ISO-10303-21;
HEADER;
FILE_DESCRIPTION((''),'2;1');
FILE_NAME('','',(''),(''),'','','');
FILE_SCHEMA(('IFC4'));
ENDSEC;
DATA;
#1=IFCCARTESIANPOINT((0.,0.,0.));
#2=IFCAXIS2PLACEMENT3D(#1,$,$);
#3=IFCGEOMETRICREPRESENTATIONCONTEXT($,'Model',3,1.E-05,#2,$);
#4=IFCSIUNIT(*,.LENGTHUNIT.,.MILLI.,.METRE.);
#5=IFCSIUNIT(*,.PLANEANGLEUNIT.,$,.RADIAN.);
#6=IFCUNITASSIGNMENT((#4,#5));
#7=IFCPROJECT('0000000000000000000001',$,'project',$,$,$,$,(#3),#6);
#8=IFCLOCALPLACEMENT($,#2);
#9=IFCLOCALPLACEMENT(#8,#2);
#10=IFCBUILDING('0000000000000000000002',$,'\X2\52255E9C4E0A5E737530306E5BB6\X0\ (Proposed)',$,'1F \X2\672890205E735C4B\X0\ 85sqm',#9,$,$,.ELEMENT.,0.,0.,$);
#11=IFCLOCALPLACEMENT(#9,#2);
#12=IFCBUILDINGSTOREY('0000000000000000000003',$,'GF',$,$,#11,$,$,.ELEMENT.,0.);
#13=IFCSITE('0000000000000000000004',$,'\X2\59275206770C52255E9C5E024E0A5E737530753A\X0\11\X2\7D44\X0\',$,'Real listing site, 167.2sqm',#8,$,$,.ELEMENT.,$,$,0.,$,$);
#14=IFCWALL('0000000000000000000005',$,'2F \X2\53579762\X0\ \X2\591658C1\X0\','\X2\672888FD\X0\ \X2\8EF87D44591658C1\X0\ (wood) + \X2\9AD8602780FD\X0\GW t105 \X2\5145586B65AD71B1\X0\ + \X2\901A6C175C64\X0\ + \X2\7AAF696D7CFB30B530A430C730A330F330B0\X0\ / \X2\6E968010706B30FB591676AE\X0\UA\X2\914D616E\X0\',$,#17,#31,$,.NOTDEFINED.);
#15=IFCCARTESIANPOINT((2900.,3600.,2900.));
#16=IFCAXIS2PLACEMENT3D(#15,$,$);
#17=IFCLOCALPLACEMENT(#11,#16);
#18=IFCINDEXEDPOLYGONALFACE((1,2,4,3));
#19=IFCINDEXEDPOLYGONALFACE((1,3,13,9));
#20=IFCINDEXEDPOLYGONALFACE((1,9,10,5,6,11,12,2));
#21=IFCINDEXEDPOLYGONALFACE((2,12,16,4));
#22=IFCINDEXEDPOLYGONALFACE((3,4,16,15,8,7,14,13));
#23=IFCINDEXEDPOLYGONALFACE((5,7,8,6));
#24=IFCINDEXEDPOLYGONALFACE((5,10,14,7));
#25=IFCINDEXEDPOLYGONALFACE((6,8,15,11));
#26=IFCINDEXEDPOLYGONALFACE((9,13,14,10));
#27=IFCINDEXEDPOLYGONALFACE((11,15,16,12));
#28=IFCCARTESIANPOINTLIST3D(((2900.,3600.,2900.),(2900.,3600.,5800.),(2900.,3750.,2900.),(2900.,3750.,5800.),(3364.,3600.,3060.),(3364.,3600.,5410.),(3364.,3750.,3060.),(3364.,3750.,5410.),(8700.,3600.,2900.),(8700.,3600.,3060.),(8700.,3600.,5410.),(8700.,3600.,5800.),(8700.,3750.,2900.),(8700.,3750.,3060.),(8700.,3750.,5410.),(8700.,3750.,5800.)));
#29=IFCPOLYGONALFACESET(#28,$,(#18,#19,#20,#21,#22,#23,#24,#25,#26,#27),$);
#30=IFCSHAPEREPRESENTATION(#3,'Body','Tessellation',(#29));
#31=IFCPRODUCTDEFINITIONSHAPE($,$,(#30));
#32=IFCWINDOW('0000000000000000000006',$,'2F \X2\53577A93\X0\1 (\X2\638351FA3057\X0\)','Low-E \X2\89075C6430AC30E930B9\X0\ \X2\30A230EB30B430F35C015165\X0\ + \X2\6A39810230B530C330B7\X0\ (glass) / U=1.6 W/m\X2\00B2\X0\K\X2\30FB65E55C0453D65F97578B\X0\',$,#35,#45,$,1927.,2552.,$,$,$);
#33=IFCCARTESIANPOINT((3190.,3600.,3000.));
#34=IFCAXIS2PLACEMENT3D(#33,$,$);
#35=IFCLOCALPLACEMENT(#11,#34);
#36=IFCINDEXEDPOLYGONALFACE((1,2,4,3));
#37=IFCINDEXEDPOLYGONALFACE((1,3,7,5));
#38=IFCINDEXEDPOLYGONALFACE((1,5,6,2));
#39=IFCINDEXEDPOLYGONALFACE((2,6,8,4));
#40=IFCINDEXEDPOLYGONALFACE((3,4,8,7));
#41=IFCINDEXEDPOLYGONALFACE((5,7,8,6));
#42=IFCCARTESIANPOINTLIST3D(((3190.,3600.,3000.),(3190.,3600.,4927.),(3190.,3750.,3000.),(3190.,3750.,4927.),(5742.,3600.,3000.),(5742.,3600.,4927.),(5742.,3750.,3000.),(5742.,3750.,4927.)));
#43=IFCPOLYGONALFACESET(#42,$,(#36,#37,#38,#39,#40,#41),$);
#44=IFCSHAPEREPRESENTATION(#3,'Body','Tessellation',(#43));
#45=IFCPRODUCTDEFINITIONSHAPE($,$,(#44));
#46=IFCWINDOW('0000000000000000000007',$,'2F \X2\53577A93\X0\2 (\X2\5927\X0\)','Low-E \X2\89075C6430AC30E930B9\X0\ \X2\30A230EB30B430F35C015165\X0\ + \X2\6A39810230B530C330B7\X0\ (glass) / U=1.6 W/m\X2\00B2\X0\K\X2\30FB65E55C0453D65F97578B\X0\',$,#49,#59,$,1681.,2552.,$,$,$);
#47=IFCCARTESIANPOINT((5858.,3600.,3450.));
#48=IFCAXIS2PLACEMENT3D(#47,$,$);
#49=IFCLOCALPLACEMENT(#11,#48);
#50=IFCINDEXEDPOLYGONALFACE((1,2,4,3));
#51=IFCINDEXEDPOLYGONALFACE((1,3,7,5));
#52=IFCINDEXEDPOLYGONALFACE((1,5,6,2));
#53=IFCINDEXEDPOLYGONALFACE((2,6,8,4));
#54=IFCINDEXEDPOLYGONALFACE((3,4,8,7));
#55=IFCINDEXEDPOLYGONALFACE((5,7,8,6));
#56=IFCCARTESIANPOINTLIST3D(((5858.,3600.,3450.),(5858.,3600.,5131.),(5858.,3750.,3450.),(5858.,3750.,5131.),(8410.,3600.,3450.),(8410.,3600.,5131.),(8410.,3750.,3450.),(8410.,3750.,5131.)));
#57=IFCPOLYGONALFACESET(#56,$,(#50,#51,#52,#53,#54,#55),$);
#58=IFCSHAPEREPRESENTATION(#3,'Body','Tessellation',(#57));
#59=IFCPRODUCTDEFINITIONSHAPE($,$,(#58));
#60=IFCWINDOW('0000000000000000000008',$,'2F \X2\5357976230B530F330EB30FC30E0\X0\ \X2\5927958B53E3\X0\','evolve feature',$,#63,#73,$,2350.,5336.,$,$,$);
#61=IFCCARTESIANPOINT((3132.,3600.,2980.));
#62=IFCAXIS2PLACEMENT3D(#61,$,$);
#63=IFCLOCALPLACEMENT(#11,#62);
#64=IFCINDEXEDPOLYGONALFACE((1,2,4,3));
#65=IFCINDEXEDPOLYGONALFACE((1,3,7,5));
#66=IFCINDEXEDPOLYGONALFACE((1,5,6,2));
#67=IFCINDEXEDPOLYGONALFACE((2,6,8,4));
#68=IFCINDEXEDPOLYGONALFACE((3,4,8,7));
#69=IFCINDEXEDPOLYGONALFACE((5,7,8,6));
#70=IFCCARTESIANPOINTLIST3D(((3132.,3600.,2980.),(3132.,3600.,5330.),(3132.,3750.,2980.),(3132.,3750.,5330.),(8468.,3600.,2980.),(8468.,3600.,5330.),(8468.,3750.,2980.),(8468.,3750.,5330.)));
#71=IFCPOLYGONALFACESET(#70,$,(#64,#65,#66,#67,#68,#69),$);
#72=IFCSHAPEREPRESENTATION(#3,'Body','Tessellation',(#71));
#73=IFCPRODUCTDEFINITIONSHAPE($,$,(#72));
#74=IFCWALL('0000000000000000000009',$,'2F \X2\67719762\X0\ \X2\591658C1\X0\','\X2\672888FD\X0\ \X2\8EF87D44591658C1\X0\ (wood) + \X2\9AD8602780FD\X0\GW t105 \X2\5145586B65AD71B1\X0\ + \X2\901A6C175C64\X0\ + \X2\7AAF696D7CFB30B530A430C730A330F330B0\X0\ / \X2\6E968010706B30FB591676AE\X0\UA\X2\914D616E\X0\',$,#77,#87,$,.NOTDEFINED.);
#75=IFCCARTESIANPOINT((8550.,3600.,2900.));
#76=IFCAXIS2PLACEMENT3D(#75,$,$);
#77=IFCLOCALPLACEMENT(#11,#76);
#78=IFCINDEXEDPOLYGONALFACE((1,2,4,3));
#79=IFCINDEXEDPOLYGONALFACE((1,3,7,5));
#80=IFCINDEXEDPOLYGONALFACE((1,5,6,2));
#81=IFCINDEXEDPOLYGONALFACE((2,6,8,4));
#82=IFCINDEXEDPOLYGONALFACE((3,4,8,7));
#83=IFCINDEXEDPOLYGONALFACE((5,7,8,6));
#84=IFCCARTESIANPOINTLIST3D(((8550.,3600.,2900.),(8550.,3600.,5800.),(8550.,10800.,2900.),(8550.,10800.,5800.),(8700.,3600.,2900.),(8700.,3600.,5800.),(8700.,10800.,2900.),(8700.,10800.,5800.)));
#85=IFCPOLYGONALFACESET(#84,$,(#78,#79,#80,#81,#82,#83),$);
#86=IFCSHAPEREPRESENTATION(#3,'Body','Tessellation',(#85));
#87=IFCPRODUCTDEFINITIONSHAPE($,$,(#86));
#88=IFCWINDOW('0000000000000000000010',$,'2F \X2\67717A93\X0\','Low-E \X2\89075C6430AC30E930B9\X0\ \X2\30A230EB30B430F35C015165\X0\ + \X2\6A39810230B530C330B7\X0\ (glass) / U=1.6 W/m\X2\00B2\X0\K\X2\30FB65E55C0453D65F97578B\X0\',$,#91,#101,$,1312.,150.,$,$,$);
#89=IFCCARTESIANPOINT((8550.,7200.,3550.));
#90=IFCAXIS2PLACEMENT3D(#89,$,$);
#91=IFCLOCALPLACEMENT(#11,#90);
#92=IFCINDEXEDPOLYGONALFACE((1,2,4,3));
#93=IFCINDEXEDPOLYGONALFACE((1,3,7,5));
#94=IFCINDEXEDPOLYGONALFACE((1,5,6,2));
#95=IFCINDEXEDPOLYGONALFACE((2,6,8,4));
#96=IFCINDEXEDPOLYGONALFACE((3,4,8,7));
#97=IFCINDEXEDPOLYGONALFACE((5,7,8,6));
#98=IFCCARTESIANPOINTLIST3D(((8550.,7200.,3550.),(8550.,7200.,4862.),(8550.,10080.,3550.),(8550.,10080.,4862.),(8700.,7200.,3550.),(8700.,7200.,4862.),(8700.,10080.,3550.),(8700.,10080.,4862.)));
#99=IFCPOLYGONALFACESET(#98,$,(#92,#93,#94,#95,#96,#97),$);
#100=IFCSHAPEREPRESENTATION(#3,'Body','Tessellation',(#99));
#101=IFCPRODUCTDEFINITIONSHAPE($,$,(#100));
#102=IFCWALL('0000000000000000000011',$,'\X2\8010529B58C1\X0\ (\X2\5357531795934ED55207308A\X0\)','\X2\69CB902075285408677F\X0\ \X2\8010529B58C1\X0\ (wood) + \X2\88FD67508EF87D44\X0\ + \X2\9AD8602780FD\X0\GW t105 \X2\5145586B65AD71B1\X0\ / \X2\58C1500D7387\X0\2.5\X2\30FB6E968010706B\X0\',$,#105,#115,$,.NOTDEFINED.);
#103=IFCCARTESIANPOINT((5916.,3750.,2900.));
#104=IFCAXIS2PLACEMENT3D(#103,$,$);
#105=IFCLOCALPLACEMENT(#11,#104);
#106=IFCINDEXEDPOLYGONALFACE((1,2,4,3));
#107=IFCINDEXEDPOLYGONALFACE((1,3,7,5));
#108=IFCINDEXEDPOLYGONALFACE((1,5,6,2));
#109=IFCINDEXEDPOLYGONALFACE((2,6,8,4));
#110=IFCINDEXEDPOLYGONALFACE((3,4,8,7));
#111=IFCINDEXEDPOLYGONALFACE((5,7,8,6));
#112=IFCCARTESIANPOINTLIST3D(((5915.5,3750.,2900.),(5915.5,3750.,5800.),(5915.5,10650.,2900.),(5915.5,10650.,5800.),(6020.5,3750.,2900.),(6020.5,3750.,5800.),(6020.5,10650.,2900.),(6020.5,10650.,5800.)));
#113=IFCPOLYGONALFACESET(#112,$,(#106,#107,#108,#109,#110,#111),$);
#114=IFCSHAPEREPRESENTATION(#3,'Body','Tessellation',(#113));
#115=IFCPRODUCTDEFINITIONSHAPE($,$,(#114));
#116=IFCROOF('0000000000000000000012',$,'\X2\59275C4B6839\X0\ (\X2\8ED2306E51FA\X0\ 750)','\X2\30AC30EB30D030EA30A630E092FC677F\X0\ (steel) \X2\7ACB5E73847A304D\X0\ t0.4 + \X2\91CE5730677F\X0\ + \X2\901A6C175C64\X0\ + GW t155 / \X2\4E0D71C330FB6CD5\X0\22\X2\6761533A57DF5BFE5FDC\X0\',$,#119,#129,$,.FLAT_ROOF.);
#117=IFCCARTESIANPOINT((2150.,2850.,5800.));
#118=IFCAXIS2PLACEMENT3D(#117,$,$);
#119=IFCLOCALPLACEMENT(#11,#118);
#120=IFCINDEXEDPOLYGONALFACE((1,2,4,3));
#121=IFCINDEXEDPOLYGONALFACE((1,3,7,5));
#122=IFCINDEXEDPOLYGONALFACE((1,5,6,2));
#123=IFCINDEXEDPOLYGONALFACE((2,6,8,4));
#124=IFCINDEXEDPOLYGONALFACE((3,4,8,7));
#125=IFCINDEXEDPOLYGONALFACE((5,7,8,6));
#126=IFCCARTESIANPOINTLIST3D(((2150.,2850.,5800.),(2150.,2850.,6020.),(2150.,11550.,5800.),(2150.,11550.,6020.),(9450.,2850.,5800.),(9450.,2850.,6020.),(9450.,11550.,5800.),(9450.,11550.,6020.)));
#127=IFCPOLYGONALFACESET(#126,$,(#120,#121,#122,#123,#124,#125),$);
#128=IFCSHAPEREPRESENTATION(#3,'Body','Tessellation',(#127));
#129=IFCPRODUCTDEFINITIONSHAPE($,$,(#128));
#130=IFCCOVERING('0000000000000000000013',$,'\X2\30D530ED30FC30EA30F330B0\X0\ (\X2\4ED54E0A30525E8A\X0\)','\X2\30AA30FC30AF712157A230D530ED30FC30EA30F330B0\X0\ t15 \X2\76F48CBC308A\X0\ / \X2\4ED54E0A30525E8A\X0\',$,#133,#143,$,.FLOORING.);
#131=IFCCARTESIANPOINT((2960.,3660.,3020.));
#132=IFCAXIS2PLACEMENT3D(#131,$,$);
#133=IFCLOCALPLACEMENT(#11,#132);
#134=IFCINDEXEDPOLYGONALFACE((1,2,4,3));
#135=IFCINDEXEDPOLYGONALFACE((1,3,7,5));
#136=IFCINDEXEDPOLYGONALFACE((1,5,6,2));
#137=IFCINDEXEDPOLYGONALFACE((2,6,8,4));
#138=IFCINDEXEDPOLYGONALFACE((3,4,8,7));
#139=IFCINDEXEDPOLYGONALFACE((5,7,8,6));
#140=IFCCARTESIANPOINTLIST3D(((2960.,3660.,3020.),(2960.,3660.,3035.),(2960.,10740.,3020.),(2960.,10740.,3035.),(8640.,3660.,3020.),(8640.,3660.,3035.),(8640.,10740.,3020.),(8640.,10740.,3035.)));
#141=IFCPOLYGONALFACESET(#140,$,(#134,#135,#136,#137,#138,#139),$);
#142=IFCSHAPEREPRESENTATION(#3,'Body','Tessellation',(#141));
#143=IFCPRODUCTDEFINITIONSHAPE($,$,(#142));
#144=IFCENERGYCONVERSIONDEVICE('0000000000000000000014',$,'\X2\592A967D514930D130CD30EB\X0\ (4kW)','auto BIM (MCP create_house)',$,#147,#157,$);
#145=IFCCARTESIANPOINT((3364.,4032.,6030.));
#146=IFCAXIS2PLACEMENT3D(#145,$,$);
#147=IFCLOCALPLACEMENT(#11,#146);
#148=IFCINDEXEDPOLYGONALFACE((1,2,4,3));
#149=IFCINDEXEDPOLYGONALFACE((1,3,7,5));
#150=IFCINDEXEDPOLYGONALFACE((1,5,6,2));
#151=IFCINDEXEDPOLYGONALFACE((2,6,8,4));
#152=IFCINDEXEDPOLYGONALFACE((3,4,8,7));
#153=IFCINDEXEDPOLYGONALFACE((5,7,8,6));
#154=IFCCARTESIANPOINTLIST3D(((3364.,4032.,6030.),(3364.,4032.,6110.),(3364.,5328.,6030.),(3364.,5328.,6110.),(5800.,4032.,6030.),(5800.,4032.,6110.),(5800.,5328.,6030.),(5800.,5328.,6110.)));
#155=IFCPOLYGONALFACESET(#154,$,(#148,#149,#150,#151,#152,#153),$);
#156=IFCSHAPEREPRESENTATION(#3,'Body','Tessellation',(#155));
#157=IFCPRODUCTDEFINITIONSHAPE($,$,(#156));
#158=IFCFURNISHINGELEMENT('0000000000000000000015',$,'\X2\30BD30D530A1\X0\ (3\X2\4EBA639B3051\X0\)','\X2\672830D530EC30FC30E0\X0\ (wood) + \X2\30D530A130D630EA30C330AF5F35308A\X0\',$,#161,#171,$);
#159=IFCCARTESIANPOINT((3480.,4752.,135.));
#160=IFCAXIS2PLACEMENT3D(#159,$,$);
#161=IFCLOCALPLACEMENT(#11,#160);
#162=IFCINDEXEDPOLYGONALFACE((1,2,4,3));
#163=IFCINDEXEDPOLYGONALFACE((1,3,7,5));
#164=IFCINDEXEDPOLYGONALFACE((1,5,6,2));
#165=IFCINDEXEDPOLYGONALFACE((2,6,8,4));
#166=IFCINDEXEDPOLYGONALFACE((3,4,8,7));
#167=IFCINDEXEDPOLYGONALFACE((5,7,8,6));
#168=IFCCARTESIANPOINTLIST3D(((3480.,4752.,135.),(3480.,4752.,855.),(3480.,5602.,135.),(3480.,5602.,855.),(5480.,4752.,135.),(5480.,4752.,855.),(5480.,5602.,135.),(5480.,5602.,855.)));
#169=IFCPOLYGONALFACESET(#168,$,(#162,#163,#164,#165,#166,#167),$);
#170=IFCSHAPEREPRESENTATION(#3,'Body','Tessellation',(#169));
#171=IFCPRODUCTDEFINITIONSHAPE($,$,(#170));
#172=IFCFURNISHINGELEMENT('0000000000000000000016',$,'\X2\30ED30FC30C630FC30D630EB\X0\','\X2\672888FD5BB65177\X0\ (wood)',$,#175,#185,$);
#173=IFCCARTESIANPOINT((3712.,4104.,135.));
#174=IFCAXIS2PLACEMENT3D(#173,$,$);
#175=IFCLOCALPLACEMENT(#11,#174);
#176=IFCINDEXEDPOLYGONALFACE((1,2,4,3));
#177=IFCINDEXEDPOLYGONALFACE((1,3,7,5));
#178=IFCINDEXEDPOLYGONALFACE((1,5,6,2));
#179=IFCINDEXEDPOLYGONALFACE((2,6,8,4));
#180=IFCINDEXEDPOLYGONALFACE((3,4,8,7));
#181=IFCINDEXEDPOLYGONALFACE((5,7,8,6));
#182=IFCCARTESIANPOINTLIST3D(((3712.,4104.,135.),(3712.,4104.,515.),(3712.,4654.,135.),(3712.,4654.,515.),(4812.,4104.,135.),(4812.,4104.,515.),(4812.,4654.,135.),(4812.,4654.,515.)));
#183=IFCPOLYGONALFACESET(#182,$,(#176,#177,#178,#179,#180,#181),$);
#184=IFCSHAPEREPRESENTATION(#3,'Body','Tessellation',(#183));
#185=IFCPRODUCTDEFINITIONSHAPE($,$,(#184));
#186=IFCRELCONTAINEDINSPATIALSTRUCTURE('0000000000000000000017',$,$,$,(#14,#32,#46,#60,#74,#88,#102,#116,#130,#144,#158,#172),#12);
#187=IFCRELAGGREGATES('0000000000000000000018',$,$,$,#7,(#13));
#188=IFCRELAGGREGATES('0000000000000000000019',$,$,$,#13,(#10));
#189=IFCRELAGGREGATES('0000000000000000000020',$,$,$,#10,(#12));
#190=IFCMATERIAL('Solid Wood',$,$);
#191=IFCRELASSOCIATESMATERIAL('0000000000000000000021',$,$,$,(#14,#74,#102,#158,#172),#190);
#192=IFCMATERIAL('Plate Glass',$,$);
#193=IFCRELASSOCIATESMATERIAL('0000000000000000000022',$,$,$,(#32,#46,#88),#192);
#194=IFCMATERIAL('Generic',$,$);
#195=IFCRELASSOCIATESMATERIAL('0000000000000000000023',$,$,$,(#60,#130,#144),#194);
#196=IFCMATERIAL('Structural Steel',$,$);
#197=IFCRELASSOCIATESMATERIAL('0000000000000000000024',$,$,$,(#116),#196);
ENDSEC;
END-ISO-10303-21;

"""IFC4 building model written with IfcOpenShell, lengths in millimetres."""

from ifc_helpers import new_model, si_unit, frame, frame_2d, origin, place, context, project, spatial, rectangle, extrude, material, element, fill, save


model = new_model("IFC4")

# Units and contexts
model_context = context("Model", 3, precision=1e-05, world=origin())
ifc_project = project(units=[si_unit("LENGTHUNIT", "METRE", prefix="MILLI"), si_unit("PLANEANGLEUNIT", "RADIAN")], contexts=[model_context])

# Site, building, storey
site_placement = place(None, origin())
site = spatial("IfcSite", under=ifc_project, at=site_placement, Name="大分県別府市上平田町11組", ObjectType="Real listing site, 167.2sqm", CompositionType="ELEMENT", RefElevation=0.0)
building_placement = place(site_placement, origin())
building = spatial("IfcBuilding", under=site, at=building_placement, Name="別府上平田の家 (Proposed)", ObjectType="1F 木造平屋 85sqm", CompositionType="ELEMENT", ElevationOfRefHeight=0.0, ElevationOfTerrain=0.0)
storey_placement = place(building_placement, origin())
storey = spatial("IfcBuildingStorey", under=building, at=storey_placement, Name="GF", CompositionType="ELEMENT", Elevation=0.0)

# Shared definitions
ifc_material_1 = material(Name="Solid Wood")

# Wall, openings, windows
wall_1_placement = place(storey_placement, frame((2900.0, 3600.0, 2900.0)))
wall_1 = element("IfcWall", 1, at=wall_1_placement, inside=storey, material=ifc_material_1, Name="2F 南面 外壁", Description="木製 軸組外壁 (wood) + 高性能GW t105 充填断熱 + 通気層 + 窯業系サイディング / 準耐火・外皮UA配慮", PredefinedType="NOTDEFINED", context=model_context, shape_type="SweptSolid", body=[
    extrude(rectangle(XDim=5800.0, YDim=150.0, at=frame_2d((2900.0, 75.0))), frame((2900.0, 3600.0, 2900.0)), (0.0, 0.0, 1.0), 2900.0),
])
opening_1_placement = place(storey_placement, frame((3190.0, 3600.0, 3000.0)))
opening_1 = element("IfcOpeningElement", 2, at=opening_1_placement, cuts=wall_1, PredefinedType="NOTDEFINED", context=model_context, shape_type="SweptSolid", body=[
    extrude(rectangle(XDim=2552.0, YDim=150.0, at=frame_2d((1276.0, 75.0))), frame((3190.0, 3600.0, 3000.0)), (0.0, 0.0, 1.0), 1927.0),
])
opening_2_placement = place(storey_placement, frame((5858.0, 3600.0, 3450.0)))
opening_2 = element("IfcOpeningElement", 3, at=opening_2_placement, cuts=wall_1, PredefinedType="NOTDEFINED", context=model_context, shape_type="SweptSolid", body=[
    extrude(rectangle(XDim=2552.0, YDim=150.0, at=frame_2d((1276.0, 75.0))), frame((5858.0, 3600.0, 3450.0)), (0.0, 0.0, 1.0), 1681.0),
])
opening_3_placement = place(storey_placement, frame((3132.0, 3600.0, 2980.0)))
opening_3 = element("IfcOpeningElement", 4, at=opening_3_placement, cuts=wall_1, PredefinedType="NOTDEFINED", context=model_context, shape_type="SweptSolid", body=[
    extrude(rectangle(XDim=5336.0, YDim=150.0, at=frame_2d((2668.0, 75.0))), frame((3132.0, 3600.0, 2980.0)), (0.0, 0.0, 1.0), 2350.0),
])
ifc_material_2 = material(Name="Plate Glass")
window_1_placement = place(storey_placement, frame((3190.0, 3600.0, 3000.0)))
window_1 = element("IfcWindow", 5, at=window_1_placement, inside=storey, material=ifc_material_2, Name="2F 南窓1 (掃出し)", Description="Low-E 複層ガラス アルゴン封入 + 樹脂サッシ (glass) / U=1.6 W/m²K・日射取得型", OverallHeight=1927.0, OverallWidth=2552.0, context=model_context, shape_type="SweptSolid", body=[
    extrude(rectangle(XDim=2552.0, YDim=150.0, at=frame_2d((1276.0, 75.0))), frame((3190.0, 3600.0, 3000.0)), (0.0, 0.0, 1.0), 1927.0),
])
fill(opening_1, window_1)
window_2_placement = place(storey_placement, frame((5858.0, 3600.0, 3450.0)))
window_2 = element("IfcWindow", 6, at=window_2_placement, inside=storey, material=ifc_material_2, Name="2F 南窓2 (大)", Description="Low-E 複層ガラス アルゴン封入 + 樹脂サッシ (glass) / U=1.6 W/m²K・日射取得型", OverallHeight=1681.0, OverallWidth=2552.0, context=model_context, shape_type="SweptSolid", body=[
    extrude(rectangle(XDim=2552.0, YDim=150.0, at=frame_2d((1276.0, 75.0))), frame((5858.0, 3600.0, 3450.0)), (0.0, 0.0, 1.0), 1681.0),
])
fill(opening_2, window_2)
ifc_material_3 = material(Name="Generic")
window_3_placement = place(storey_placement, frame((3132.0, 3600.0, 2980.0)))
window_3 = element("IfcWindow", 7, at=window_3_placement, inside=storey, material=ifc_material_3, Name="2F 南面サンルーム 大開口", Description="evolve feature", OverallHeight=2350.0, OverallWidth=5336.0, context=model_context, shape_type="SweptSolid", body=[
    extrude(rectangle(XDim=5336.0, YDim=150.0, at=frame_2d((2668.0, 75.0))), frame((3132.0, 3600.0, 2980.0)), (0.0, 0.0, 1.0), 2350.0),
])
fill(opening_3, window_3)

# Wall, opening, window
wall_2_placement = place(storey_placement, frame((8550.0, 3600.0, 2900.0)))
wall_2 = element("IfcWall", 8, at=wall_2_placement, inside=storey, material=ifc_material_1, Name="2F 東面 外壁", Description="木製 軸組外壁 (wood) + 高性能GW t105 充填断熱 + 通気層 + 窯業系サイディング / 準耐火・外皮UA配慮", PredefinedType="NOTDEFINED", context=model_context, shape_type="SweptSolid", body=[
    extrude(rectangle(XDim=150.0, YDim=7200.0, at=frame_2d((75.0, 3600.0))), frame((8550.0, 3600.0, 2900.0)), (0.0, 0.0, 1.0), 2900.0),
])
opening_4_placement = place(storey_placement, frame((8550.0, 7200.0, 3550.0)))
opening_4 = element("IfcOpeningElement", 9, at=opening_4_placement, cuts=wall_2, PredefinedType="NOTDEFINED", context=model_context, shape_type="SweptSolid", body=[
    extrude(rectangle(XDim=150.0, YDim=2880.0, at=frame_2d((75.0, 1440.0))), frame((8550.0, 7200.0, 3550.0)), (0.0, 0.0, 1.0), 1312.0),
])
window_4_placement = place(storey_placement, frame((8550.0, 7200.0, 3550.0)))
window_4 = element("IfcWindow", 10, at=window_4_placement, inside=storey, material=ifc_material_2, Name="2F 東窓", Description="Low-E 複層ガラス アルゴン封入 + 樹脂サッシ (glass) / U=1.6 W/m²K・日射取得型", OverallHeight=1312.0, OverallWidth=150.0, context=model_context, shape_type="SweptSolid", body=[
    extrude(rectangle(XDim=150.0, YDim=2880.0, at=frame_2d((75.0, 1440.0))), frame((8550.0, 7200.0, 3550.0)), (0.0, 0.0, 1.0), 1312.0),
])
fill(opening_4, window_4)

# Wall
wall_3_placement = place(storey_placement, frame((5916.0, 3750.0, 2900.0)))
element("IfcWall", 11, at=wall_3_placement, inside=storey, material=ifc_material_1, Name="耐力壁 (南北間仕切り)", Description="構造用合板 耐力壁 (wood) + 製材軸組 + 高性能GW t105 充填断熱 / 壁倍率2.5・準耐火", PredefinedType="NOTDEFINED", context=model_context, shape_type="SweptSolid", body=[
    extrude(rectangle(XDim=105.0, YDim=6900.0, at=frame_2d((52.0, 3450.0))), frame((5916.0, 3750.0, 2900.0)), (0.0, 0.0, 1.0), 2900.0),
])

# Roof
ifc_material_4 = material(Name="Structural Steel")
roof_placement = place(storey_placement, frame((2150.0, 2850.0, 5800.0)))
element("IfcRoof", 12, at=roof_placement, inside=storey, material=ifc_material_4, Name="大屋根 (軒の出 750)", Description="ガルバリウム鋼板 (steel) 立平葺き t0.4 + 野地板 + 通気層 + GW t155 / 不燃・法22条区域対応", PredefinedType="FLAT_ROOF", context=model_context, shape_type="SweptSolid", body=[
    extrude(rectangle(XDim=7300.0, YDim=8700.0, at=frame_2d((3650.0, 4350.0))), frame((2150.0, 2850.0, 5800.0)), (0.0, 0.0, 1.0), 220.0),
])

# Covering
covering_placement = place(storey_placement, frame((2960.0, 3660.0, 3020.0)))
element("IfcCovering", 13, at=covering_placement, inside=storey, material=ifc_material_3, Name="フローリング (仕上げ床)", Description="オーク無垢フローリング t15 直貼り / 仕上げ床", PredefinedType="FLOORING", context=model_context, shape_type="SweptSolid", body=[
    extrude(rectangle(XDim=5680.0, YDim=7080.0, at=frame_2d((2840.0, 3540.0))), frame((2960.0, 3660.0, 3020.0)), (0.0, 0.0, 1.0), 15.0),
])

# Energy conversion device
energy_conversion_device_placement = place(storey_placement, frame((3364.0, 4032.0, 6030.0)))
element("IfcEnergyConversionDevice", 14, at=energy_conversion_device_placement, inside=storey, material=ifc_material_3, Name="太陽光パネル (4kW)", Description="auto BIM (MCP create_house)", context=model_context, shape_type="SweptSolid", body=[
    extrude(rectangle(XDim=2436.0, YDim=1296.0, at=frame_2d((1218.0, 648.0))), frame((3364.0, 4032.0, 6030.0)), (0.0, 0.0, 1.0), 80.0),
])

# Furnishing elements
furnishing_1_placement = place(storey_placement, frame((3480.0, 4752.0, 135.0)))
element("IfcFurnishingElement", 15, at=furnishing_1_placement, inside=storey, material=ifc_material_1, Name="ソファ (3人掛け)", Description="木フレーム (wood) + ファブリック張り", context=model_context, shape_type="SweptSolid", body=[
    extrude(rectangle(XDim=2000.0, YDim=850.0, at=frame_2d((1000.0, 425.0))), frame((3480.0, 4752.0, 135.0)), (0.0, 0.0, 1.0), 720.0),
])
furnishing_2_placement = place(storey_placement, frame((3712.0, 4104.0, 135.0)))
element("IfcFurnishingElement", 16, at=furnishing_2_placement, inside=storey, material=ifc_material_1, Name="ローテーブル", Description="木製家具 (wood)", context=model_context, shape_type="SweptSolid", body=[
    extrude(rectangle(XDim=1100.0, YDim=550.0, at=frame_2d((550.0, 275.0))), frame((3712.0, 4104.0, 135.0)), (0.0, 0.0, 1.0), 380.0),
])

save(model, "model.ifc")
